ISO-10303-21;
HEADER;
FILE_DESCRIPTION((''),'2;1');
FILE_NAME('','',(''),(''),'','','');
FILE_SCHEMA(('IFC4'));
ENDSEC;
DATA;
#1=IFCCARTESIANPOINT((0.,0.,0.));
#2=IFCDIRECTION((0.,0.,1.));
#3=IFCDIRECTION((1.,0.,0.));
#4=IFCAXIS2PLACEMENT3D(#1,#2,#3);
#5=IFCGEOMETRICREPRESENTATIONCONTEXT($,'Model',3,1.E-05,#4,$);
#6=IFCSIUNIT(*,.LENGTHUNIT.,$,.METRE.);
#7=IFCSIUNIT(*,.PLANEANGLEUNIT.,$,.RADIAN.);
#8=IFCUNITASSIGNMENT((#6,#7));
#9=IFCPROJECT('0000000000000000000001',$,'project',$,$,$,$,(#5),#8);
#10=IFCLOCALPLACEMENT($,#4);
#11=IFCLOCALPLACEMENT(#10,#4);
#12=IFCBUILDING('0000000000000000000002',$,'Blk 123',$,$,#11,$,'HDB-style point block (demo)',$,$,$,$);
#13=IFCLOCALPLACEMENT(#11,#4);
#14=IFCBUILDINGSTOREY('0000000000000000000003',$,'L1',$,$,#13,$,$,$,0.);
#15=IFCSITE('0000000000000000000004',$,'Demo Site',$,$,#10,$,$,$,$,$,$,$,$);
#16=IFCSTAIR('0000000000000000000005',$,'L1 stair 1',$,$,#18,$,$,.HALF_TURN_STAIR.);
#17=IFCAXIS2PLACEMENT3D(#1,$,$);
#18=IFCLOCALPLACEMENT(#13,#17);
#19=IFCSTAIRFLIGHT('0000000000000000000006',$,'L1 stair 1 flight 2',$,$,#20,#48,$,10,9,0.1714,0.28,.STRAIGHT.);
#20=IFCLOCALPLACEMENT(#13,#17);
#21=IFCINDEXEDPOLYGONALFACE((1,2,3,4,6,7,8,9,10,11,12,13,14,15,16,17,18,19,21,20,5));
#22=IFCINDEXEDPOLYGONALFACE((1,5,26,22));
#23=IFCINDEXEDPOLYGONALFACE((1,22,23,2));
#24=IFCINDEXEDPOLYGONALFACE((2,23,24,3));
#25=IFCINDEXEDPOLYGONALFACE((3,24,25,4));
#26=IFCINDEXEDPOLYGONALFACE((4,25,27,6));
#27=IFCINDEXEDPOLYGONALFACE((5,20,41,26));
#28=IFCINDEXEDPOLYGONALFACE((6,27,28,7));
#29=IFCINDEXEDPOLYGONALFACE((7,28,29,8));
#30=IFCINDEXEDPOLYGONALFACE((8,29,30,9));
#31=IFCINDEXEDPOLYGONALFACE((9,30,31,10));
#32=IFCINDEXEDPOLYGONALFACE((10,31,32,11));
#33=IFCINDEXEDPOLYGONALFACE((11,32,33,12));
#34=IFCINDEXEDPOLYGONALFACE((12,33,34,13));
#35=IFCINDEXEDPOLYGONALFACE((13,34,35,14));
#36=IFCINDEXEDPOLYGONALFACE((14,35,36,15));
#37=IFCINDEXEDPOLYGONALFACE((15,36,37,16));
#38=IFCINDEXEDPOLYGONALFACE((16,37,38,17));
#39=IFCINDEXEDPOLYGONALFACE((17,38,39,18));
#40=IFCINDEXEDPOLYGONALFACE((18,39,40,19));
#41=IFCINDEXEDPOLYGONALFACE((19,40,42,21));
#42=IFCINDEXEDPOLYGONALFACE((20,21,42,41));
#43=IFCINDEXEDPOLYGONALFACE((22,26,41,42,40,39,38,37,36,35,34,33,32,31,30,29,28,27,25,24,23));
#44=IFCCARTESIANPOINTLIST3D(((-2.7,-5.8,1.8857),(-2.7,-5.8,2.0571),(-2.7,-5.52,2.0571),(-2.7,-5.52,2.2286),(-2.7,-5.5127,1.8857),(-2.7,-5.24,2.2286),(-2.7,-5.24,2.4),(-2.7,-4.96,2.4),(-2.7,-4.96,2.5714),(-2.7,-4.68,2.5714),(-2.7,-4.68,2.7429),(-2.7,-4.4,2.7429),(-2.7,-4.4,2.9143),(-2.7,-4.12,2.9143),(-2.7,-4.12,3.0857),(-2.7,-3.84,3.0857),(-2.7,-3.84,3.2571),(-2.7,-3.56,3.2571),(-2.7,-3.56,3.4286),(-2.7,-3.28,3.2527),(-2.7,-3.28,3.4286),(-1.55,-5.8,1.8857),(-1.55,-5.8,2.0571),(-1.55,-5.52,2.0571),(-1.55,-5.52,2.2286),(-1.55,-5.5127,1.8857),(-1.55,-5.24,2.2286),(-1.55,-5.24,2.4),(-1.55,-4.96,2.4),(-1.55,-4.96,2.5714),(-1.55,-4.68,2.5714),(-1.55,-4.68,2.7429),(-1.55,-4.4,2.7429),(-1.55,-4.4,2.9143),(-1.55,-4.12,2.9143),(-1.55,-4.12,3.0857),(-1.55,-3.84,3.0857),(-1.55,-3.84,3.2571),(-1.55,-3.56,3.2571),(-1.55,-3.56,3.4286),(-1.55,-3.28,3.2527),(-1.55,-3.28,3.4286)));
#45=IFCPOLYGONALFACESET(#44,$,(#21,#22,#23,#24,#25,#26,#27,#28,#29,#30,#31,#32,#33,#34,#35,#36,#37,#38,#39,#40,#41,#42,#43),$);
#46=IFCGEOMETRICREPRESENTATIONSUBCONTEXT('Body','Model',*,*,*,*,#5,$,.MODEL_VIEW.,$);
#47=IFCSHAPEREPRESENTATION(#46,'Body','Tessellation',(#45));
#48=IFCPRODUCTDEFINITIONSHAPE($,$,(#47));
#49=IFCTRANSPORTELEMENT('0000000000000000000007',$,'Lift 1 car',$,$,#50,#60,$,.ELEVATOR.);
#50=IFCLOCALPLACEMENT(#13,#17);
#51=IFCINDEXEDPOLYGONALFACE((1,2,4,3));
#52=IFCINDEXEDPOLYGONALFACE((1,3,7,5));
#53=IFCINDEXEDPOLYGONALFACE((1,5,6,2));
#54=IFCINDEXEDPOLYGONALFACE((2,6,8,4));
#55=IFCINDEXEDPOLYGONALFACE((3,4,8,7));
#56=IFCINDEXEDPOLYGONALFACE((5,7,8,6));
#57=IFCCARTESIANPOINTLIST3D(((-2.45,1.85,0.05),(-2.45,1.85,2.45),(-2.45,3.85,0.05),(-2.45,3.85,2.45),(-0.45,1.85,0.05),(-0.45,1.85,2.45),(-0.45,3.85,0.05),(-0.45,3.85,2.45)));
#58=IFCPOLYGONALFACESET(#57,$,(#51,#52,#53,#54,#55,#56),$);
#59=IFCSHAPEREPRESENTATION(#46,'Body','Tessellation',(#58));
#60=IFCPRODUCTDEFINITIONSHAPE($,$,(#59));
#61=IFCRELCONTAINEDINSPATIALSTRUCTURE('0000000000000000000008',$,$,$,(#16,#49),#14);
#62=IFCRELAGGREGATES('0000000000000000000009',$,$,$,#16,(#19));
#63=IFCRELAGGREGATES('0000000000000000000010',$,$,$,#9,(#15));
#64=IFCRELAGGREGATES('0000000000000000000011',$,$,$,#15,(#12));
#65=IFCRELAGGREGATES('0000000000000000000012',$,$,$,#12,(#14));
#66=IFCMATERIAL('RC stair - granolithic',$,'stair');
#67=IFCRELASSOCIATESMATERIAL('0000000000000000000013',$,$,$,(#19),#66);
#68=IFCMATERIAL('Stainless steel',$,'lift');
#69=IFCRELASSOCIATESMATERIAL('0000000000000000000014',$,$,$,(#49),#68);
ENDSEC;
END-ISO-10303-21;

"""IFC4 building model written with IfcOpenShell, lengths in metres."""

from ifc_helpers import new_model, si_unit, frame, origin, origin_with_axes, place, context, subcontext, project, spatial, polyline, outline, extrude, material, element, aggregate, save


model = new_model("IFC4")

# Units and contexts
model_context = context("Model", 3, precision=1e-05, world=origin_with_axes())
body_context = subcontext(model_context, "Body", "Model", "MODEL_VIEW")
ifc_project = project(units=[si_unit("LENGTHUNIT", "METRE"), si_unit("PLANEANGLEUNIT", "RADIAN")], contexts=[model_context])

# Site, building, storey
site_placement = place(None, origin_with_axes())
site = spatial("IfcSite", under=ifc_project, at=site_placement, Name="Demo Site")
building_placement = place(site_placement, origin_with_axes())
building = spatial("IfcBuilding", under=site, at=building_placement, Name="Blk 123", LongName="HDB-style point block (demo)")
storey_placement = place(building_placement, origin_with_axes())
storey = spatial("IfcBuildingStorey", under=building, at=storey_placement, Name="L1", Elevation=0.0)

# Stair
stair_placement = place(storey_placement, frame((-2.7, -7.1, 0.0), z_axis=(0.0, 0.0, 1.0), x_axis=(1.0, 0.0, 0.0)))
stair = element("IfcStair", 1, at=stair_placement, inside=storey, Name="L1 stair 1", PredefinedType="HALF_TURN_STAIR")
ifc_material_1 = material(Name="RC stair - granolithic", Category="stair")

# Shared definitions
ifc_material_2 = material(Name="Stainless steel", Category="lift")

# Stair flight
stair_flight_1_placement = place(stair_placement, frame((0.0, 1.3, 1.8857), z_axis=(0.0, 0.0, 1.0), x_axis=(1.0, 0.0, 0.0)))
stair_flight_1 = element("IfcStairFlight", 2, at=stair_flight_1_placement, material=ifc_material_1, Name="L1 stair 1 flight 2", NumberOfRisers=10, NumberOfTreads=9, PredefinedType="STRAIGHT", RiserHeight=0.1714, TreadLength=0.28, context=body_context, shape_type="SweptSolid", body=[
    extrude(outline(polyline([(0.0, 0.0), (0.0, 0.1714), (0.28, 0.1714), (0.28, 0.3429), (0.56, 0.3429), (0.56, 0.5143), (0.84, 0.5143), (0.84, 0.6857), (1.12, 0.6857), (1.12, 0.8571), (1.4, 0.8571), (1.4, 1.0286), (1.68, 1.0286), (1.68, 1.2), (1.96, 1.2), (1.96, 1.3714), (2.24, 1.3714), (2.24, 1.5429), (2.52, 1.5429), (2.52, 1.7143), (2.52, 1.367), (0.2873, 0.0), (0.0, 0.0)])), frame((0.0, 0.0, 0.0), z_axis=(1.0, 0.0, 0.0), x_axis=(0.0, 1.0, 0.0)), (0.0, 0.0, 1.0), 1.15),
])

aggregate(stair, [stair_flight_1])

# Transport element
transport_element_placement = place(storey_placement, frame((-1.45, 2.85, 0.05), z_axis=(0.0, 0.0, 1.0), x_axis=(1.0, 0.0, 0.0)))
element("IfcTransportElement", 3, at=transport_element_placement, inside=storey, material=ifc_material_2, Name="Lift 1 car", PredefinedType="ELEVATOR", context=body_context, shape_type="SweptSolid", body=[
    extrude(outline(polyline([(1.0, -1.0), (1.0, 1.0), (-1.0, 1.0), (-1.0, -1.0), (1.0, -1.0)])), origin(), (0.0, 0.0, 1.0), 2.4),
])

save(model, "model.ifc")
